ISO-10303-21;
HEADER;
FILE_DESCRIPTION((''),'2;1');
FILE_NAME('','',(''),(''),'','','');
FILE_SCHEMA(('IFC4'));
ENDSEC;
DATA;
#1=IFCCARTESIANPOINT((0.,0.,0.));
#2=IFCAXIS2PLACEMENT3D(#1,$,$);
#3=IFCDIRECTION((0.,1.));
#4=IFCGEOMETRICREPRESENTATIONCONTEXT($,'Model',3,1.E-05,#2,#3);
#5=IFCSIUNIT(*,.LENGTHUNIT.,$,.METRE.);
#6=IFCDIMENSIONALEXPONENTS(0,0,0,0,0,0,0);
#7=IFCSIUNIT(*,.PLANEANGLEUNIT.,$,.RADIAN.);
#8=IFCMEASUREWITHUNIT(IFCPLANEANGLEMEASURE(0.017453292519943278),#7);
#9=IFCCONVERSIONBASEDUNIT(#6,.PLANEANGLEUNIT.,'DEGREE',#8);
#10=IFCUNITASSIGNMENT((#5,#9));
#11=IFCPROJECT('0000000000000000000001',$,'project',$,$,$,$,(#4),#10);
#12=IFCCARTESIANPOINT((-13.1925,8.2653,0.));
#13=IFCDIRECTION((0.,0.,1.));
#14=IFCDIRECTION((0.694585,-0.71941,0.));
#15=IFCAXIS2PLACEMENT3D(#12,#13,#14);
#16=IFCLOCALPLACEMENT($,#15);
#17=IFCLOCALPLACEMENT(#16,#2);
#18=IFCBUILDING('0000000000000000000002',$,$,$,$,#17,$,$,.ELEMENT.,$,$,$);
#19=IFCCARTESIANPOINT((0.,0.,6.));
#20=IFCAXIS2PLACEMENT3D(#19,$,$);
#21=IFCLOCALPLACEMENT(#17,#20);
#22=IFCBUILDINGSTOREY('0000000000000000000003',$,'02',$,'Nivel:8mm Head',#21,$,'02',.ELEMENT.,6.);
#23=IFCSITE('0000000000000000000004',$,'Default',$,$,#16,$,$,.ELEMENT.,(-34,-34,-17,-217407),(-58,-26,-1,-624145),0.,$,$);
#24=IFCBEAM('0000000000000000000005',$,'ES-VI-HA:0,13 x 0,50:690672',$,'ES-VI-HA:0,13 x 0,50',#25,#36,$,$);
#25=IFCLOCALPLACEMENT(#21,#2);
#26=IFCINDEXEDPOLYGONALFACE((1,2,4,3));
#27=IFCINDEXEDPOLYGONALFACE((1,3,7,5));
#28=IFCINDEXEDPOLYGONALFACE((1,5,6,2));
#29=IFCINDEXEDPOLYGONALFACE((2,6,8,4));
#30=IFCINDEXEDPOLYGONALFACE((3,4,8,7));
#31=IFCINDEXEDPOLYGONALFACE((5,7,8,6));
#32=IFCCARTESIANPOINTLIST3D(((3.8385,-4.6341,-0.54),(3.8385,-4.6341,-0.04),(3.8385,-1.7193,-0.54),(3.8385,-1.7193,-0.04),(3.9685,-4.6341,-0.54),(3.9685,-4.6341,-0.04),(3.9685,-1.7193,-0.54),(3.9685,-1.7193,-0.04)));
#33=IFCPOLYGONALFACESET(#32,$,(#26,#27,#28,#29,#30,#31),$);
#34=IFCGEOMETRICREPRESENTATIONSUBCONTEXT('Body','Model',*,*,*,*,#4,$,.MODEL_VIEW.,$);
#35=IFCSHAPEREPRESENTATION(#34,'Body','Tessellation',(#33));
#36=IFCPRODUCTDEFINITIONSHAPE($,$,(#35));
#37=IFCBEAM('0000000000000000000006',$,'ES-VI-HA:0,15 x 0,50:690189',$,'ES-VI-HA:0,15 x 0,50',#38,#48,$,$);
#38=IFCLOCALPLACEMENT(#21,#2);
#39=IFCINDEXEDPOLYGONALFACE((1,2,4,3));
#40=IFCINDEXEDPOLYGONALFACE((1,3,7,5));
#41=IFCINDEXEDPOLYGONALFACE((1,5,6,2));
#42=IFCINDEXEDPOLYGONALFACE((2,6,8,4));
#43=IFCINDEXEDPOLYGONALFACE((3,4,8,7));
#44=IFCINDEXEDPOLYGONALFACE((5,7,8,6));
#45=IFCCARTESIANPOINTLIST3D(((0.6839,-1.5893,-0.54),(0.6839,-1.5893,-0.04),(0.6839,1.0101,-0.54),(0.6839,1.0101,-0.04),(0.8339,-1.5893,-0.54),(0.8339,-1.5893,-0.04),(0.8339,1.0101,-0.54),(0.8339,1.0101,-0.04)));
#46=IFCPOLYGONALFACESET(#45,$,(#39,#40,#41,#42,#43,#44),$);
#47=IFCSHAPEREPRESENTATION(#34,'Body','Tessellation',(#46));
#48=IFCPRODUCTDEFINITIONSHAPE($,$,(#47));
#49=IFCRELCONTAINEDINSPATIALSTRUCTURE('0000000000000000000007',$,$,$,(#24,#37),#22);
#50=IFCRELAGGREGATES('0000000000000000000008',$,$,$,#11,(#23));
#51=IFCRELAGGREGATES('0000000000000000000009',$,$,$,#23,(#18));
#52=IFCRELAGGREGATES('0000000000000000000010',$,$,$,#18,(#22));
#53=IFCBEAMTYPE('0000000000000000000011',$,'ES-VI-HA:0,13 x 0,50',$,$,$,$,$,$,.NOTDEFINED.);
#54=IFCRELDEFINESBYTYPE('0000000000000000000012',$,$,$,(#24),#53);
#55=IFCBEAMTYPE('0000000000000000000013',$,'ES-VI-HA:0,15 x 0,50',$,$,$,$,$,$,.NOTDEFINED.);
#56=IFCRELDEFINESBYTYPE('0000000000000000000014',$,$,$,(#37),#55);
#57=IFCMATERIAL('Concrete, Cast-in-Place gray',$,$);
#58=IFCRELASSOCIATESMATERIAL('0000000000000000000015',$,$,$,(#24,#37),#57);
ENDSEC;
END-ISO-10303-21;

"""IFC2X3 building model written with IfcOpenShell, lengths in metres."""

from ifc_helpers import new_model, entity, si_unit, converted_unit, direction, frame, frame_2d, origin, origin_2d_with_axis, place, context, subcontext, project, spatial, rectangle, extrude, material, type_object, element, save


model = new_model("IFC2X3")

# Units and contexts
model_context = context("Model", 3, precision=1e-05, world=origin(), true_north=direction((0.0, 1.0)))
body_context = subcontext(model_context, "Body", "Model", "MODEL_VIEW")
ifc_project = project(units=[si_unit("LENGTHUNIT", "METRE"), converted_unit("PLANEANGLEUNIT", "DEGREE", entity("IfcPlaneAngleMeasure", 0.017453292519943278), si_unit("PLANEANGLEUNIT", "RADIAN"), dimensions=[0, 0, 0, 0, 0, 0, 0])], contexts=[model_context])

# Site, building, storey
site_placement = place(None, frame((-13.1925, 8.2653, 0.0), z_axis=(0.0, 0.0, 1.0), x_axis=(0.694585, -0.71941, 0.0)))
site = spatial("IfcSite", under=ifc_project, at=site_placement, Name="Default", CompositionType="ELEMENT", RefLatitude=(-34, -34, -17, -217407), RefLongitude=(-58, -26, -1, -624145), RefElevation=0.0)
building_placement = place(site_placement, origin())
building = spatial("IfcBuilding", under=site, at=building_placement, CompositionType="ELEMENT")
storey_placement = place(building_placement, frame((0.0, 0.0, 6.0)))
storey = spatial("IfcBuildingStorey", under=building, at=storey_placement, Name="02", ObjectType="Nivel:8mm Head", LongName="02", CompositionType="ELEMENT", Elevation=6.0)

# Beams
ifc_material_1 = material(Name="Concrete, Cast-in-Place gray")
beam_type_1 = type_object("IfcBeamType", Name="ES-VI-HA:0,13 x 0,50", PredefinedType="NOTDEFINED")
beam_1_placement = place(storey_placement, frame((3.9035, -4.7011, -0.04), z_axis=(0.0, 0.0, 1.0), x_axis=(0.0, 1.0, 0.0)))
element("IfcBeam", 1, at=beam_1_placement, inside=storey, type_object=beam_type_1, material=ifc_material_1, Name="ES-VI-HA:0,13 x 0,50:690672", ObjectType="ES-VI-HA:0,13 x 0,50", context=body_context, shape_type="SweptSolid", body=[
    extrude(rectangle(XDim=0.5, YDim=0.13, at=origin_2d_with_axis()), frame((0.067, 0.0, -0.25), z_axis=(1.0, 0.0, 0.0), x_axis=(0.0, 0.0, -1.0)), (0.0, 0.0, 1.0), 2.9148),
])
beam_type_2 = type_object("IfcBeamType", Name="ES-VI-HA:0,15 x 0,50", PredefinedType="NOTDEFINED")
beam_2_placement = place(storey_placement, frame((0.7589, -1.6543, -0.04), z_axis=(0.0, 0.0, 1.0), x_axis=(0.0, 1.0, 0.0)))
element("IfcBeam", 2, at=beam_2_placement, inside=storey, type_object=beam_type_2, material=ifc_material_1, Name="ES-VI-HA:0,15 x 0,50:690189", ObjectType="ES-VI-HA:0,15 x 0,50", context=body_context, shape_type="SweptSolid", body=[
    extrude(rectangle(XDim=0.5, YDim=0.15, at=frame_2d((0.0, 0.0), x_axis=(1.0, 0.0))), frame((0.065, 0.0, -0.25), z_axis=(1.0, 0.0, 0.0), x_axis=(0.0, 0.0, -1.0)), (0.0, 0.0, 1.0), 2.5994),
])

save(model, "model.ifc")
